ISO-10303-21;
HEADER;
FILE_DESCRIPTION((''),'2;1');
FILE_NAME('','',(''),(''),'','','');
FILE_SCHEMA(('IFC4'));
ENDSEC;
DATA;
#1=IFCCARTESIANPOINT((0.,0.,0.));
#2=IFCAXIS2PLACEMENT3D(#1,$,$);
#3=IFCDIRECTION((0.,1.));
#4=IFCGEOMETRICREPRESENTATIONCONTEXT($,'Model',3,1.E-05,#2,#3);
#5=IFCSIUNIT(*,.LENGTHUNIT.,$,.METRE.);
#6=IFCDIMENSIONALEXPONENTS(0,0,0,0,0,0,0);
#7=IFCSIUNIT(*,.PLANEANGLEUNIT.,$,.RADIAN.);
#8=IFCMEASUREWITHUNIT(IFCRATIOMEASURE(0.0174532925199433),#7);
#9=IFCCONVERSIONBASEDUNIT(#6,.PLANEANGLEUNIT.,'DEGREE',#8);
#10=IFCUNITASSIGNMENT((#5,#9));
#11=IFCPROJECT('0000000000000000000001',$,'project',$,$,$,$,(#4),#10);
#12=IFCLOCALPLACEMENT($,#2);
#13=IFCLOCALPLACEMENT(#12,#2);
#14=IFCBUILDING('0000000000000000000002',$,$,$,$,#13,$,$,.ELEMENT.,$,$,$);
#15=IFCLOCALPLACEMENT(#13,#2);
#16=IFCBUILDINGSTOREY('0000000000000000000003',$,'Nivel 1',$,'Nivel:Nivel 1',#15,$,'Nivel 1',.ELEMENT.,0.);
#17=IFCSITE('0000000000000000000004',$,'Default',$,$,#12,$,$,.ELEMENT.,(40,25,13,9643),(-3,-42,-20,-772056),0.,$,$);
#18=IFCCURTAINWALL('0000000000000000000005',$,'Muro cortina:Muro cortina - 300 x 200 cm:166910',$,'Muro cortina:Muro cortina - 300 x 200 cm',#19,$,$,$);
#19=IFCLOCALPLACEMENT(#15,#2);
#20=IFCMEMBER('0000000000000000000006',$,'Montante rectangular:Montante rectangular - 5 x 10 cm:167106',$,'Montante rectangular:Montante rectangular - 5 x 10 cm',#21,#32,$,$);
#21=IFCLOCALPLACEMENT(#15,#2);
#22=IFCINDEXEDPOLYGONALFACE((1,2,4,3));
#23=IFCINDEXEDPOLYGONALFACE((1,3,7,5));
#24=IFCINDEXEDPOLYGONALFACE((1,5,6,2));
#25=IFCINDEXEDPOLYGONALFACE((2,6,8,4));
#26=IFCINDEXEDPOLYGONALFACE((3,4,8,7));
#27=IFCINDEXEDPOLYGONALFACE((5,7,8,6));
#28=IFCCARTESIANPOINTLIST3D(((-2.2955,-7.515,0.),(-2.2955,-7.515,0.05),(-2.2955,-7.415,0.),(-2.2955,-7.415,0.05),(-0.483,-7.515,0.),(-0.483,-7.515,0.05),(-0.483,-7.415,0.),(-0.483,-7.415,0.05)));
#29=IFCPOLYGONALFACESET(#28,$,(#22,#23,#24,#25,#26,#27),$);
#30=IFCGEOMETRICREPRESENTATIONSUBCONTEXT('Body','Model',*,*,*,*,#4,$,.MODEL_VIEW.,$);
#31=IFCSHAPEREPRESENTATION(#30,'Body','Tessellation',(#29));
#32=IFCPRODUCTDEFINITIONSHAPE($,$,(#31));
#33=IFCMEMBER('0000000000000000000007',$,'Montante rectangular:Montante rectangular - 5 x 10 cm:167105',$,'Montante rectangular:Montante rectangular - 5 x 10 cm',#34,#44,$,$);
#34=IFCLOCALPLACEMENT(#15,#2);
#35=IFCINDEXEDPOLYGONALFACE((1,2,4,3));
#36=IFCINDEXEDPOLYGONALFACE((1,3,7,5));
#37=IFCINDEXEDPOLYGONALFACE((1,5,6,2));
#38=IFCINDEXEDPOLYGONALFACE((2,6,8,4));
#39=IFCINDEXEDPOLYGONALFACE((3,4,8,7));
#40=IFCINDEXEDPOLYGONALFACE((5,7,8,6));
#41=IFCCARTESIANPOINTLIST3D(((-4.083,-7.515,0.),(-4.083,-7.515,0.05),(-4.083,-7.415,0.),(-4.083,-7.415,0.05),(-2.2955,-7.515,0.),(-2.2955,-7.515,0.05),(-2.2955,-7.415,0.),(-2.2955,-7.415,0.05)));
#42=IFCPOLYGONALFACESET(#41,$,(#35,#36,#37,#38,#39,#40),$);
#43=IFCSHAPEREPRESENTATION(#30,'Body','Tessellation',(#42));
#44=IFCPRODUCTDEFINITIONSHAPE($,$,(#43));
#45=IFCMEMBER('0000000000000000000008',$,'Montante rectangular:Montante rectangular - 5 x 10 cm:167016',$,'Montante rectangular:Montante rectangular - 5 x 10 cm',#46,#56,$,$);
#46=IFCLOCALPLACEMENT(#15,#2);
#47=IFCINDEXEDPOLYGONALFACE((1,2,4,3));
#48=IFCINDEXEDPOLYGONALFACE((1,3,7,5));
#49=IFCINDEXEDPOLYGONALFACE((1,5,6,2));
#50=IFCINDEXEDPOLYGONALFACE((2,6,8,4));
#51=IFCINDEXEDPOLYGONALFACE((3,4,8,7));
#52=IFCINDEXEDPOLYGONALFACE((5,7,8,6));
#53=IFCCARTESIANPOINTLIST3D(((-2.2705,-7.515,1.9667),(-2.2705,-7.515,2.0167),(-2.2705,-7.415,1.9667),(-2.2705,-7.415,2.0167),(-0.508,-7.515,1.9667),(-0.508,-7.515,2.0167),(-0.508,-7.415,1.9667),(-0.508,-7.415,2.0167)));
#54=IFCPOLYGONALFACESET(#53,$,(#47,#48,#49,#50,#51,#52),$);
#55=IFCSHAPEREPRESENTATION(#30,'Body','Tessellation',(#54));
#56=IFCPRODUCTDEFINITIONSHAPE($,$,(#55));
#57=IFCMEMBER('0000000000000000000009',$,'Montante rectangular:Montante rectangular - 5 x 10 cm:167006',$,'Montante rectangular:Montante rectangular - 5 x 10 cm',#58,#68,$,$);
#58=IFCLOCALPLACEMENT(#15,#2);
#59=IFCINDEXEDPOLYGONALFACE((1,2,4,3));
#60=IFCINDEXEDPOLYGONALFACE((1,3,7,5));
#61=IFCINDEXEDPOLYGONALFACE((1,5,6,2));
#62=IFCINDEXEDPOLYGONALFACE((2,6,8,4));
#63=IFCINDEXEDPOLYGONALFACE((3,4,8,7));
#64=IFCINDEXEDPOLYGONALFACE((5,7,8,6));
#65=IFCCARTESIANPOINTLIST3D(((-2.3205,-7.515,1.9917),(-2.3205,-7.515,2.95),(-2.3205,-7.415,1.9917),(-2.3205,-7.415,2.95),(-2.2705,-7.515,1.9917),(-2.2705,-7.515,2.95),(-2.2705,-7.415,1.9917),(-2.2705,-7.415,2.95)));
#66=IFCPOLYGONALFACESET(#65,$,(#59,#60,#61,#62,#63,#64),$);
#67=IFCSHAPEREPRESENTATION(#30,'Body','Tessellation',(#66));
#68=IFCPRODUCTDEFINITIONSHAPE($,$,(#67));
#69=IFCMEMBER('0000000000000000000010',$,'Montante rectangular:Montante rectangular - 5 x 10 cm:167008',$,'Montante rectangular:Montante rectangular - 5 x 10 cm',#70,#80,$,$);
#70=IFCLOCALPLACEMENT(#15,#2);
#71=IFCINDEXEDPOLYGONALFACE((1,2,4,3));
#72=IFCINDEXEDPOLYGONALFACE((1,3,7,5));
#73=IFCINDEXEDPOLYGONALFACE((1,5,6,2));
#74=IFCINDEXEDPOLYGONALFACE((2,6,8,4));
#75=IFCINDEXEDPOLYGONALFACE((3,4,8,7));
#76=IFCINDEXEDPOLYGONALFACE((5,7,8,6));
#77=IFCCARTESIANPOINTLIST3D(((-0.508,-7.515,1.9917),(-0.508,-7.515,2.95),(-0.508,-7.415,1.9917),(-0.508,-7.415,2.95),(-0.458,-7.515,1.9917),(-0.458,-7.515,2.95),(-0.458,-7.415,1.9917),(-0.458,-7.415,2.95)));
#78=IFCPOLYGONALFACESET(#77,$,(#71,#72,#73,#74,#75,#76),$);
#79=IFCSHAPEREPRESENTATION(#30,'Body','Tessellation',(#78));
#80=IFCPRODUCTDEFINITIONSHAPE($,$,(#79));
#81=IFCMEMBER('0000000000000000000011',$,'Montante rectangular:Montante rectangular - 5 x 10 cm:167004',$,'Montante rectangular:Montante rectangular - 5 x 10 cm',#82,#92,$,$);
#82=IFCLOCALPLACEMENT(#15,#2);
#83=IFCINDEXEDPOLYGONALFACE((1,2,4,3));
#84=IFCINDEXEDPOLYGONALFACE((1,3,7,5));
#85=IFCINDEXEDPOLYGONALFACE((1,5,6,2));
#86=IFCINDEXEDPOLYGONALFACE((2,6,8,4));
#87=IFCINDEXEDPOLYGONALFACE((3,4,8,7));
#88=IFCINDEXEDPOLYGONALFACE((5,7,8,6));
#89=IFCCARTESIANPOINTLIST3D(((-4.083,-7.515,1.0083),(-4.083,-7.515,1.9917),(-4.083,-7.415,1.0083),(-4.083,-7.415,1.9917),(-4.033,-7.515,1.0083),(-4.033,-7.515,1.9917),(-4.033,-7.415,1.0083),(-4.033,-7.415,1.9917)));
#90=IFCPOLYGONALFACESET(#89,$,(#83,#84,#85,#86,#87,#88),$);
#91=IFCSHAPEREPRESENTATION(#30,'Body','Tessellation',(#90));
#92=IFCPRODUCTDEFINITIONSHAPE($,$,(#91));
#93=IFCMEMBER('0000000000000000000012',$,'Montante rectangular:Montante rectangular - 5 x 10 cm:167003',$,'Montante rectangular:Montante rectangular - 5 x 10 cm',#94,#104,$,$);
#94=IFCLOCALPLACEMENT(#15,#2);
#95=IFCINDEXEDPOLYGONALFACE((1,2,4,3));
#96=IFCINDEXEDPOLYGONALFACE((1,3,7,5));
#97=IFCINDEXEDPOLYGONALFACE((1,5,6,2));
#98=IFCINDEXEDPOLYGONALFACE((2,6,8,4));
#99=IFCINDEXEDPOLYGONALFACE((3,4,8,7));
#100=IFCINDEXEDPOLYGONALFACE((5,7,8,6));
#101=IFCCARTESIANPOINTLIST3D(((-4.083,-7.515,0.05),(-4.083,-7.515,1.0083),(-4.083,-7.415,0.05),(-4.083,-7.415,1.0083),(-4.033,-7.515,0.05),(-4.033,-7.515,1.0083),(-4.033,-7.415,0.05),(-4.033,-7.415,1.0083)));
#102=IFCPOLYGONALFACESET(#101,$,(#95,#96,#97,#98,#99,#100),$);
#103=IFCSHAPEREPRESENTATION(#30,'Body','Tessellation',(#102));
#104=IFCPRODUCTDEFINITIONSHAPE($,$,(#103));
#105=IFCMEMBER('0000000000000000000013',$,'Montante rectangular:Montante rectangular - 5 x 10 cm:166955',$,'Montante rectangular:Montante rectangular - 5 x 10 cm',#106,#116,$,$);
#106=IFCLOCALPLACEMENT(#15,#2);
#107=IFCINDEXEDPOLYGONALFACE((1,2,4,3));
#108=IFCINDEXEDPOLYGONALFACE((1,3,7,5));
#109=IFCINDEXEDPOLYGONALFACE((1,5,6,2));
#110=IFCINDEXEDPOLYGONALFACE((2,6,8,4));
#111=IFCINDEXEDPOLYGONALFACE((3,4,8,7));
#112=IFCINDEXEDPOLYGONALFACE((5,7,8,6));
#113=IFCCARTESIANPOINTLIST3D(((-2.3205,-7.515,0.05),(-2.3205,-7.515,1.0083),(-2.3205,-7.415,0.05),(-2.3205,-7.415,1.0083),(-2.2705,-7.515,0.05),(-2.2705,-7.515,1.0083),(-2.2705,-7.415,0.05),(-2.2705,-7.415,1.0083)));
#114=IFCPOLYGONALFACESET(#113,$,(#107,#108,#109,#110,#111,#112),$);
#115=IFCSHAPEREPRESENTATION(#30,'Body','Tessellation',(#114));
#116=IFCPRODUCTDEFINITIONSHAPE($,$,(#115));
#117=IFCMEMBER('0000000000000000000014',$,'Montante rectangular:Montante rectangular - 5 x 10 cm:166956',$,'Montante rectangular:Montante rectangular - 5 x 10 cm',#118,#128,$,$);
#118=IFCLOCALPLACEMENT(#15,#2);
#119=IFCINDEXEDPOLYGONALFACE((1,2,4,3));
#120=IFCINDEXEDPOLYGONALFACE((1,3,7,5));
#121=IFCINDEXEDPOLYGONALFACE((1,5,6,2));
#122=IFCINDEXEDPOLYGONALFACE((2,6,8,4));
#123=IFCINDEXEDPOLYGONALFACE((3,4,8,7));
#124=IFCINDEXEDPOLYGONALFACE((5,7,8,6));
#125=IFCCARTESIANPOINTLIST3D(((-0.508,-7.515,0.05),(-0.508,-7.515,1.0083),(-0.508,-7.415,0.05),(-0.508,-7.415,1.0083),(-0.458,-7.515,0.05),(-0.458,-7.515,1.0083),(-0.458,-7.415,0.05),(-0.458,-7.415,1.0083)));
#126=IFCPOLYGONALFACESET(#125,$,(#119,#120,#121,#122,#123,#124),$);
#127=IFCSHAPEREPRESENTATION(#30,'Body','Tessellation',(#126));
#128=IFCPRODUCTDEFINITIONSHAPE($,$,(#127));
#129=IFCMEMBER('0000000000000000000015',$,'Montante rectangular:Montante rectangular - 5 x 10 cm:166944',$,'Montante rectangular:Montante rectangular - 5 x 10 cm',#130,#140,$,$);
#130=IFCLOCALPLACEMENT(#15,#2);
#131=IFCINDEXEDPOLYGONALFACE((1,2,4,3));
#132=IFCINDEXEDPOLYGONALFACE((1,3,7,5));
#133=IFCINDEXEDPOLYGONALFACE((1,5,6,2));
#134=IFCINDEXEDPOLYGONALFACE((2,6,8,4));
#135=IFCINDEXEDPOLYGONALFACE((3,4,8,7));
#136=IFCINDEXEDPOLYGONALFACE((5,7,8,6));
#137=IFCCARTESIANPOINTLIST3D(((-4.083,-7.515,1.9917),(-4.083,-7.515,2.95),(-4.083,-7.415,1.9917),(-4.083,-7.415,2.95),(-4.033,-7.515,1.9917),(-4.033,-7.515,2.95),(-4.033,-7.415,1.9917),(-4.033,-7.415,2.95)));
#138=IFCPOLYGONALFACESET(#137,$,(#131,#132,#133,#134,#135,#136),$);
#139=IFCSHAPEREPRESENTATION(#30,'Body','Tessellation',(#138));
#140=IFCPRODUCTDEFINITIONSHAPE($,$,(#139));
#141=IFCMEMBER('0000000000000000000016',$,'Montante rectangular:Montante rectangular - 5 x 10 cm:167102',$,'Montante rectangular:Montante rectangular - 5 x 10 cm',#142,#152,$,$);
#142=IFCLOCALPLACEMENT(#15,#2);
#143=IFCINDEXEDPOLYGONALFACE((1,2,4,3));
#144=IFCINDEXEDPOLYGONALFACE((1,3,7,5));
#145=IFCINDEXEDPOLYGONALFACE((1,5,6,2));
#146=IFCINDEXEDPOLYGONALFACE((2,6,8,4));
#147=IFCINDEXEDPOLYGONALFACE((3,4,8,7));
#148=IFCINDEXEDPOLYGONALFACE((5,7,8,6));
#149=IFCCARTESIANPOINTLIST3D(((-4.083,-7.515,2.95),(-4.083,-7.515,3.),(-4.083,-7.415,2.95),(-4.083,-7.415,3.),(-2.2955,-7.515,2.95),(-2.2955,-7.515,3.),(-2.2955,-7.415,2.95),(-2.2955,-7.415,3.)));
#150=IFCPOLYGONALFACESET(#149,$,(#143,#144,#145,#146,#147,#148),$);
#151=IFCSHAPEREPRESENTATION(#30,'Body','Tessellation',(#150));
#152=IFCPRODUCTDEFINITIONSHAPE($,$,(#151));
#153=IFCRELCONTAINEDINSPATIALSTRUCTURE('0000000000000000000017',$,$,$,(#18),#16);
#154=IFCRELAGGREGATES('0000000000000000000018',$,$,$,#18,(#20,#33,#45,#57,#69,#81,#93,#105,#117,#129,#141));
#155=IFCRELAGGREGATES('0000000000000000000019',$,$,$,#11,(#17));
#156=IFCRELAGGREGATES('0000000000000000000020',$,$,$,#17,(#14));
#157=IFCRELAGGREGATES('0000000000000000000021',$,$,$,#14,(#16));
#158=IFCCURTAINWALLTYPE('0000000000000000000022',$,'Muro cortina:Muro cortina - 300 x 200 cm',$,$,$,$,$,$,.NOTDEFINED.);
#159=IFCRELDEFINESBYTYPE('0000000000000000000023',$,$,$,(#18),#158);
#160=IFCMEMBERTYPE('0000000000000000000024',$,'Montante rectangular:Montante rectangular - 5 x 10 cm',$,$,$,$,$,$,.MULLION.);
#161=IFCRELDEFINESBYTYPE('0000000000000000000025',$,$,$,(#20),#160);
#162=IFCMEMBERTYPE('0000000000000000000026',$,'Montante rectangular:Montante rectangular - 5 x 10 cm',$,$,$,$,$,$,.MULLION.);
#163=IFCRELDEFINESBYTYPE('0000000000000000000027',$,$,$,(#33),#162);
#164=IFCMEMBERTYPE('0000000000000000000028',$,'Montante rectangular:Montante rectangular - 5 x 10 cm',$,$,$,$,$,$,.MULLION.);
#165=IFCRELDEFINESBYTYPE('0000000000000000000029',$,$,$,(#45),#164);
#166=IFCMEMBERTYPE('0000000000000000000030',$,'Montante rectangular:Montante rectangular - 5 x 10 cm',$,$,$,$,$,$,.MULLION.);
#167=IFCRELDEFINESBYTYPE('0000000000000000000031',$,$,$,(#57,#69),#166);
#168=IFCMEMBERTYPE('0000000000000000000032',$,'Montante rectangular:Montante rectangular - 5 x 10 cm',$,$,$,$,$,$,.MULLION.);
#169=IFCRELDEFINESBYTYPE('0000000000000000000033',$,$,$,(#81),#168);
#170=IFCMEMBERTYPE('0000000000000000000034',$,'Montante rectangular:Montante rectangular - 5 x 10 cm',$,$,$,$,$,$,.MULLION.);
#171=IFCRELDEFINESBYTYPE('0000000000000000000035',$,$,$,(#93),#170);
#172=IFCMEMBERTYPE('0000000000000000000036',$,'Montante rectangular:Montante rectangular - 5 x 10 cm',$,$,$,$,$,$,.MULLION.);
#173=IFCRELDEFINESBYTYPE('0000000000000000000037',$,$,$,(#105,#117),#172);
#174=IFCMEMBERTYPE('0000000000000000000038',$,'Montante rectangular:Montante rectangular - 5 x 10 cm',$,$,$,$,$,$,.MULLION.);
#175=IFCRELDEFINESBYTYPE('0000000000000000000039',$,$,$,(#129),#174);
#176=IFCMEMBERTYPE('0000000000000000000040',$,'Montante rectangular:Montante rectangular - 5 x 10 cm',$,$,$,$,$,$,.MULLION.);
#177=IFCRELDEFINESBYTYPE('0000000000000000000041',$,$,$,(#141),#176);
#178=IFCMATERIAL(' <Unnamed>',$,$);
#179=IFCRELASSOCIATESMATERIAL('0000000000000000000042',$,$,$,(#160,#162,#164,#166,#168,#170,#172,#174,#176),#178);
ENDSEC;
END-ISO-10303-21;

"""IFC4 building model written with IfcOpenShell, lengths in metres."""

from ifc_helpers import new_model, entity, si_unit, converted_unit, direction, frame, origin, origin_2d_with_axis, place, context, subcontext, project, spatial, rectangle, extrude, source, transform, mapped, material, type_object, type_shapes, element, aggregate, save


model = new_model("IFC4")

# Units and contexts
model_context = context("Model", 3, precision=1e-05, world=origin(), true_north=direction((0.0, 1.0)))
body_context = subcontext(model_context, "Body", "Model", "MODEL_VIEW")
ifc_project = project(units=[si_unit("LENGTHUNIT", "METRE"), converted_unit("PLANEANGLEUNIT", "DEGREE", entity("IfcRatioMeasure", 0.0174532925199433), si_unit("PLANEANGLEUNIT", "RADIAN"), dimensions=[0, 0, 0, 0, 0, 0, 0])], contexts=[model_context])

# Site, building, storey
site_placement = place(None, origin())
site = spatial("IfcSite", under=ifc_project, at=site_placement, Name="Default", CompositionType="ELEMENT", RefLatitude=(40, 25, 13, 9643), RefLongitude=(-3, -42, -20, -772056), RefElevation=0.0)
building_placement = place(site_placement, origin())
building = spatial("IfcBuilding", under=site, at=building_placement, CompositionType="ELEMENT")
storey_placement = place(building_placement, origin())
storey = spatial("IfcBuildingStorey", under=building, at=storey_placement, Name="Nivel 1", ObjectType="Nivel:Nivel 1", LongName="Nivel 1", CompositionType="ELEMENT", Elevation=0.0)

# Curtain wall, members
curtain_wall_type = type_object("IfcCurtainWallType", Name="Muro cortina:Muro cortina - 300 x 200 cm", PredefinedType="NOTDEFINED")
curtain_wall_placement = place(storey_placement, origin())
curtain_wall = element("IfcCurtainWall", 1, at=curtain_wall_placement, inside=storey, type_object=curtain_wall_type, Name="Muro cortina:Muro cortina - 300 x 200 cm:166910", ObjectType="Muro cortina:Muro cortina - 300 x 200 cm")
ifc_material_1 = material(Name=" <Unnamed>")
member_type_1 = type_object("IfcMemberType", Name="Montante rectangular:Montante rectangular - 5 x 10 cm", PredefinedType="MULLION", material=ifc_material_1)
shared_shape_1 = source(origin(), body_context, "Body", "SweptSolid", [
    extrude(rectangle(XDim=0.1, YDim=0.05, at=origin_2d_with_axis()), frame((-0.025, 0.0, -1.8125), z_axis=(0.0, 0.0, 1.0), x_axis=(0.0, -1.0, 0.0)), (0.0, 0.0, 1.0), 1.8125),
])
type_shapes(member_type_1, [shared_shape_1])
member_1_placement = place(storey_placement, frame((-2.2955, -7.465, 0.0), z_axis=(-1.0, 0.0, 0.0), x_axis=(0.0, 0.0, -1.0)))
member_1 = element("IfcMember", 2, at=member_1_placement, type_object=member_type_1, Name="Montante rectangular:Montante rectangular - 5 x 10 cm:167106", ObjectType="Montante rectangular:Montante rectangular - 5 x 10 cm", context=body_context, shape_type="MappedRepresentation", body=[
    mapped(shared_shape_1, transform((0.0, 0.0, 0.0), scale=1.0)),
])
member_type_2 = type_object("IfcMemberType", Name="Montante rectangular:Montante rectangular - 5 x 10 cm", PredefinedType="MULLION", material=ifc_material_1)
shared_shape_2 = source(origin(), body_context, "Body", "SweptSolid", [
    extrude(rectangle(XDim=0.1, YDim=0.05, at=origin_2d_with_axis()), frame((-0.025, 0.0, -1.7875), z_axis=(0.0, 0.0, 1.0), x_axis=(0.0, -1.0, 0.0)), (0.0, 0.0, 1.0), 1.7875),
])
type_shapes(member_type_2, [shared_shape_2])
member_2_placement = place(storey_placement, frame((-4.083, -7.465, 0.0), z_axis=(-1.0, 0.0, 0.0), x_axis=(0.0, 0.0, -1.0)))
member_2 = element("IfcMember", 3, at=member_2_placement, type_object=member_type_2, Name="Montante rectangular:Montante rectangular - 5 x 10 cm:167105", ObjectType="Montante rectangular:Montante rectangular - 5 x 10 cm", context=body_context, shape_type="MappedRepresentation", body=[
    mapped(shared_shape_2, transform((0.0, 0.0, 0.0), scale=1.0)),
])
member_type_3 = type_object("IfcMemberType", Name="Montante rectangular:Montante rectangular - 5 x 10 cm", PredefinedType="MULLION", material=ifc_material_1)
shared_shape_3 = source(origin(), body_context, "Body", "SweptSolid", [
    extrude(rectangle(XDim=0.1, YDim=0.05, at=origin_2d_with_axis()), frame((0.0, 0.0, -1.7625), z_axis=(0.0, 0.0, 1.0), x_axis=(0.0, -1.0, 0.0)), (0.0, 0.0, 1.0), 1.7625),
])
type_shapes(member_type_3, [shared_shape_3])
member_3_placement = place(storey_placement, frame((-0.508, -7.465, 1.9917), z_axis=(1.0, 0.0, 0.0), x_axis=(0.0, 0.0, 1.0)))
member_3 = element("IfcMember", 4, at=member_3_placement, type_object=member_type_3, Name="Montante rectangular:Montante rectangular - 5 x 10 cm:167016", ObjectType="Montante rectangular:Montante rectangular - 5 x 10 cm", context=body_context, shape_type="MappedRepresentation", body=[
    mapped(shared_shape_3, transform((0.0, 0.0, 0.0), scale=1.0)),
])
member_type_4 = type_object("IfcMemberType", Name="Montante rectangular:Montante rectangular - 5 x 10 cm", PredefinedType="MULLION", material=ifc_material_1)
shared_shape_4 = source(origin(), body_context, "Body", "SweptSolid", [
    extrude(rectangle(XDim=0.1, YDim=0.05, at=origin_2d_with_axis()), frame((0.0, 0.0, -0.9583), z_axis=(0.0, 0.0, 1.0), x_axis=(0.0, -1.0, 0.0)), (0.0, 0.0, 1.0), 0.9583),
])
type_shapes(member_type_4, [shared_shape_4])
member_4_placement = place(storey_placement, frame((-2.2955, -7.465, 1.9917), z_axis=(0.0, 0.0, -1.0), x_axis=(1.0, 0.0, 0.0)))
member_4 = element("IfcMember", 5, at=member_4_placement, type_object=member_type_4, Name="Montante rectangular:Montante rectangular - 5 x 10 cm:167006", ObjectType="Montante rectangular:Montante rectangular - 5 x 10 cm", context=body_context, shape_type="MappedRepresentation", body=[
    mapped(shared_shape_4, transform((0.0, 0.0, 0.0), scale=1.0)),
])
member_5_placement = place(storey_placement, frame((-0.483, -7.465, 1.9917), z_axis=(0.0, 0.0, -1.0), x_axis=(1.0, 0.0, 0.0)))
member_5 = element("IfcMember", 6, at=member_5_placement, type_object=member_type_4, Name="Montante rectangular:Montante rectangular - 5 x 10 cm:167008", ObjectType="Montante rectangular:Montante rectangular - 5 x 10 cm", context=body_context, shape_type="MappedRepresentation", body=[
    mapped(shared_shape_4, transform((0.0, 0.0, 0.0), scale=1.0)),
])
member_type_5 = type_object("IfcMemberType", Name="Montante rectangular:Montante rectangular - 5 x 10 cm", PredefinedType="MULLION", material=ifc_material_1)
shared_shape_5 = source(origin(), body_context, "Body", "SweptSolid", [
    extrude(rectangle(XDim=0.1, YDim=0.05, at=origin_2d_with_axis()), frame((-0.025, 0.0, -0.9833), z_axis=(0.0, 0.0, 1.0), x_axis=(0.0, -1.0, 0.0)), (0.0, 0.0, 1.0), 0.9833),
])
type_shapes(member_type_5, [shared_shape_5])
member_6_placement = place(storey_placement, frame((-4.083, -7.465, 1.9917), z_axis=(0.0, 0.0, 1.0), x_axis=(-1.0, 0.0, 0.0)))
member_6 = element("IfcMember", 7, at=member_6_placement, type_object=member_type_5, Name="Montante rectangular:Montante rectangular - 5 x 10 cm:167004", ObjectType="Montante rectangular:Montante rectangular - 5 x 10 cm", context=body_context, shape_type="MappedRepresentation", body=[
    mapped(shared_shape_5, transform((0.0, 0.0, 0.0), scale=1.0)),
])
member_type_6 = type_object("IfcMemberType", Name="Montante rectangular:Montante rectangular - 5 x 10 cm", PredefinedType="MULLION", material=ifc_material_1)
shared_shape_6 = source(origin(), body_context, "Body", "SweptSolid", [
    extrude(rectangle(XDim=0.1, YDim=0.05, at=origin_2d_with_axis()), frame((-0.025, 0.0, -0.9583), z_axis=(0.0, 0.0, 1.0), x_axis=(0.0, -1.0, 0.0)), (0.0, 0.0, 1.0), 0.9583),
])
type_shapes(member_type_6, [shared_shape_6])
member_7_placement = place(storey_placement, frame((-4.083, -7.465, 1.0083), z_axis=(0.0, 0.0, 1.0), x_axis=(-1.0, 0.0, 0.0)))
member_7 = element("IfcMember", 8, at=member_7_placement, type_object=member_type_6, Name="Montante rectangular:Montante rectangular - 5 x 10 cm:167003", ObjectType="Montante rectangular:Montante rectangular - 5 x 10 cm", context=body_context, shape_type="MappedRepresentation", body=[
    mapped(shared_shape_6, transform((0.0, 0.0, 0.0), scale=1.0)),
])
member_type_7 = type_object("IfcMemberType", Name="Montante rectangular:Montante rectangular - 5 x 10 cm", PredefinedType="MULLION", material=ifc_material_1)
shared_shape_7 = source(origin(), body_context, "Body", "SweptSolid", [
    extrude(rectangle(XDim=0.1, YDim=0.05, at=origin_2d_with_axis()), frame((0.0, 0.0, -0.9583), z_axis=(0.0, 0.0, 1.0), x_axis=(0.0, -1.0, 0.0)), (0.0, 0.0, 1.0), 0.9583),
])
type_shapes(member_type_7, [shared_shape_7])
member_8_placement = place(storey_placement, frame((-2.2955, -7.465, 0.05), z_axis=(0.0, 0.0, -1.0), x_axis=(1.0, 0.0, 0.0)))
member_8 = element("IfcMember", 9, at=member_8_placement, type_object=member_type_7, Name="Montante rectangular:Montante rectangular - 5 x 10 cm:166955", ObjectType="Montante rectangular:Montante rectangular - 5 x 10 cm", context=body_context, shape_type="MappedRepresentation", body=[
    mapped(shared_shape_7, transform((0.0, 0.0, 0.0), scale=1.0)),
])
member_9_placement = place(storey_placement, frame((-0.483, -7.465, 0.05), z_axis=(0.0, 0.0, -1.0), x_axis=(1.0, 0.0, 0.0)))
member_9 = element("IfcMember", 10, at=member_9_placement, type_object=member_type_7, Name="Montante rectangular:Montante rectangular - 5 x 10 cm:166956", ObjectType="Montante rectangular:Montante rectangular - 5 x 10 cm", context=body_context, shape_type="MappedRepresentation", body=[
    mapped(shared_shape_7, transform((0.0, 0.0, 0.0), scale=1.0)),
])
member_type_8 = type_object("IfcMemberType", Name="Montante rectangular:Montante rectangular - 5 x 10 cm", PredefinedType="MULLION", material=ifc_material_1)
shared_shape_8 = source(origin(), body_context, "Body", "SweptSolid", [
    extrude(rectangle(XDim=0.1, YDim=0.05, at=origin_2d_with_axis()), frame((-0.025, 0.0, -0.9583), z_axis=(0.0, 0.0, 1.0), x_axis=(0.0, -1.0, 0.0)), (0.0, 0.0, 1.0), 0.9583),
])
type_shapes(member_type_8, [shared_shape_8])
member_10_placement = place(storey_placement, frame((-4.083, -7.465, 2.95), z_axis=(0.0, 0.0, 1.0), x_axis=(-1.0, 0.0, 0.0)))
member_10 = element("IfcMember", 11, at=member_10_placement, type_object=member_type_8, Name="Montante rectangular:Montante rectangular - 5 x 10 cm:166944", ObjectType="Montante rectangular:Montante rectangular - 5 x 10 cm", context=body_context, shape_type="MappedRepresentation", body=[
    mapped(shared_shape_8, transform((0.0, 0.0, 0.0), scale=1.0)),
])
member_type_9 = type_object("IfcMemberType", Name="Montante rectangular:Montante rectangular - 5 x 10 cm", PredefinedType="MULLION", material=ifc_material_1)
shared_shape_9 = source(origin(), body_context, "Body", "SweptSolid", [
    extrude(rectangle(XDim=0.1, YDim=0.05, at=origin_2d_with_axis()), frame((-0.025, 0.0, -1.7875), z_axis=(0.0, 0.0, 1.0), x_axis=(0.0, -1.0, 0.0)), (0.0, 0.0, 1.0), 1.7875),
])
type_shapes(member_type_9, [shared_shape_9])
member_11_placement = place(storey_placement, frame((-2.2955, -7.465, 3.0), z_axis=(1.0, 0.0, 0.0), x_axis=(0.0, 0.0, 1.0)))
member_11 = element("IfcMember", 12, at=member_11_placement, type_object=member_type_9, Name="Montante rectangular:Montante rectangular - 5 x 10 cm:167102", ObjectType="Montante rectangular:Montante rectangular - 5 x 10 cm", context=body_context, shape_type="MappedRepresentation", body=[
    mapped(shared_shape_9, transform((0.0, 0.0, 0.0), scale=1.0)),
])
aggregate(curtain_wall, [member_1, member_2, member_3, member_4, member_5, member_6, member_7, member_8, member_9, member_10, member_11])

save(model, "model.ifc")
